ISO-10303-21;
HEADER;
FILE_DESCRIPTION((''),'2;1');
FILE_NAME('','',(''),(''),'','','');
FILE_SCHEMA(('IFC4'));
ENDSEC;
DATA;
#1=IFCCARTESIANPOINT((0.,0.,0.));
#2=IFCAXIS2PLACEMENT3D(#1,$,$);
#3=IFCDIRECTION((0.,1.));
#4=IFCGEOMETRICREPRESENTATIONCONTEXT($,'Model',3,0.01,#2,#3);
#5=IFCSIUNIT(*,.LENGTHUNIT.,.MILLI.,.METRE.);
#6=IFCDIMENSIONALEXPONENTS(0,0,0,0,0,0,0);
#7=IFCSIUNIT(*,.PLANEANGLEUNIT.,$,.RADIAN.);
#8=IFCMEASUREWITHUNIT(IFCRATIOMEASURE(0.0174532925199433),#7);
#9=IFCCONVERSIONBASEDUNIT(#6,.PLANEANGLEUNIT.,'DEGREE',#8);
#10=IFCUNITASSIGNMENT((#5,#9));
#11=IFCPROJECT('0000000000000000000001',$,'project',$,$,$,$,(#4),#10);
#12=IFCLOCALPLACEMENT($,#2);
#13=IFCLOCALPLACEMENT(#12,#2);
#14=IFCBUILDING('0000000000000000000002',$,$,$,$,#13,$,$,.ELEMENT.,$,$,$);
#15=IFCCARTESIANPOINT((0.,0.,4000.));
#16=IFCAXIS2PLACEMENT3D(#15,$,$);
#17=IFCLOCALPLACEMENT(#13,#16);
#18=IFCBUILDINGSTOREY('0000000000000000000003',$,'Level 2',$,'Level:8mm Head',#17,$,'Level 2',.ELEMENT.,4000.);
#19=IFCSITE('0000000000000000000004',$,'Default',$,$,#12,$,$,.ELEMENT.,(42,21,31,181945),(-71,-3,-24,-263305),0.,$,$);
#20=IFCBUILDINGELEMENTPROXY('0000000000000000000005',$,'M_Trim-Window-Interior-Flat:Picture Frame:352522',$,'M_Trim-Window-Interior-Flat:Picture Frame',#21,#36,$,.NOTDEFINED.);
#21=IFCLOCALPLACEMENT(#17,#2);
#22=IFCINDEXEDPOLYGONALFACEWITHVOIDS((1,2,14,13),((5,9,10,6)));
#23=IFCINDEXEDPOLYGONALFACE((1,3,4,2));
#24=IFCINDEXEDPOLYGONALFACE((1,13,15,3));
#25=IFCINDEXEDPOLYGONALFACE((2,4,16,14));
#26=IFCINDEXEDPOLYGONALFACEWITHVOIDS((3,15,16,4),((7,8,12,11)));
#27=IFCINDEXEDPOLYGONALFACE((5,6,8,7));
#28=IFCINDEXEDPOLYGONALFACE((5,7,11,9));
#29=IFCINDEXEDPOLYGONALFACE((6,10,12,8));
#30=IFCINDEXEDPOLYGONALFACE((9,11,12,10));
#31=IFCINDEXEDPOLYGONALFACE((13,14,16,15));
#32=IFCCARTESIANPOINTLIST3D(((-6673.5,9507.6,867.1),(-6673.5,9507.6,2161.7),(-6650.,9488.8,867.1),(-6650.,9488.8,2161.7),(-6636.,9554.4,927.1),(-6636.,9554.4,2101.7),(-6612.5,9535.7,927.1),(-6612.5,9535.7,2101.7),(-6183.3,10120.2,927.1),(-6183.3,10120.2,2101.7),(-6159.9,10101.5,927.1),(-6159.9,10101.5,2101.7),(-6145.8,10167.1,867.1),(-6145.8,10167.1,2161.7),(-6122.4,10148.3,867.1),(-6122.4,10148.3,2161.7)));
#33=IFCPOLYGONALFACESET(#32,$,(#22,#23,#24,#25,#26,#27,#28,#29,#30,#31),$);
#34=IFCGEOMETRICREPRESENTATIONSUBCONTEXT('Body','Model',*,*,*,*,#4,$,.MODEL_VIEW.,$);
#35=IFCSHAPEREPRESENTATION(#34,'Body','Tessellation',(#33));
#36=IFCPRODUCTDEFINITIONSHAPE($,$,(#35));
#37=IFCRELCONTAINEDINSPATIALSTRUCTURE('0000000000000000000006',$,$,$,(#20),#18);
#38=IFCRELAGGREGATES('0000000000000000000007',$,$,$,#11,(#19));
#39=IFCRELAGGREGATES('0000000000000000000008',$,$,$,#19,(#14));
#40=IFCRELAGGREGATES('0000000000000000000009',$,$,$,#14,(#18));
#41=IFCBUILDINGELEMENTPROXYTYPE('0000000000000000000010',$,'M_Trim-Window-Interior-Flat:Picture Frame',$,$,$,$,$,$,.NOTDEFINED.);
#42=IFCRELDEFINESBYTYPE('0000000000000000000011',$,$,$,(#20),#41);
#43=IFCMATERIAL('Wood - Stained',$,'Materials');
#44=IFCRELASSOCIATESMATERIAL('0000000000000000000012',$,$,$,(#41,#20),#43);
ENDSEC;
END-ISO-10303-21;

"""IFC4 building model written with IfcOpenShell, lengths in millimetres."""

from ifc_helpers import new_model, entity, si_unit, converted_unit, direction, frame, origin, place, context, subcontext, project, spatial, polyline, outline, extrude, source, transform, mapped, material, type_object, type_shapes, element, save


model = new_model("IFC4")

# Units and contexts
model_context = context("Model", 3, precision=0.01, world=origin(), true_north=direction((0.0, 1.0)))
body_context = subcontext(model_context, "Body", "Model", "MODEL_VIEW")
ifc_project = project(units=[si_unit("LENGTHUNIT", "METRE", prefix="MILLI"), converted_unit("PLANEANGLEUNIT", "DEGREE", entity("IfcRatioMeasure", 0.0174532925199433), si_unit("PLANEANGLEUNIT", "RADIAN"), dimensions=[0, 0, 0, 0, 0, 0, 0])], contexts=[model_context])

# Site, building, storey
site_placement = place(None, origin())
site = spatial("IfcSite", under=ifc_project, at=site_placement, Name="Default", CompositionType="ELEMENT", RefLatitude=(42, 21, 31, 181945), RefLongitude=(-71, -3, -24, -263305), RefElevation=0.0)
building_placement = place(site_placement, origin())
building = spatial("IfcBuilding", under=site, at=building_placement, CompositionType="ELEMENT")
storey_placement = place(building_placement, frame((0.0, 0.0, 4000.0)))
storey = spatial("IfcBuildingStorey", under=building, at=storey_placement, Name="Level 2", ObjectType="Level:8mm Head", LongName="Level 2", CompositionType="ELEMENT", Elevation=4000.0)

# Shared definitions
ifc_material_1 = material(Name="Wood - Stained", Category="Materials")

# Building element proxy
building_element_proxy_type_1 = type_object("IfcBuildingElementProxyType", Name="M_Trim-Window-Interior-Flat:Picture Frame", PredefinedType="NOTDEFINED", material=ifc_material_1)
shared_shape_1 = source(origin(), body_context, "Body", "SweptSolid", [
    extrude(outline(polyline([(-422.3, -647.3), (422.3, -647.3), (422.3, 647.3), (-422.3, 647.3), (-422.3, -647.3)]), holes=[polyline([(-362.3, -587.3), (-362.3, 587.3), (362.3, 587.3), (362.3, -587.3), (-362.3, -587.3)])]), frame((0.0, -600.0, 0.0), z_axis=(0.0, 0.0, 1.0), x_axis=(-1.0, 0.0, 0.0)), (0.0, 0.0, 1.0), 30.0),
])
type_shapes(building_element_proxy_type_1, [shared_shape_1])
for number, where, z_axis, x_axis, name in (
    (1, (-6386.2, 9818.6, 2114.4), (-0.780869, 0.624695, 0.0), (-0.624695, -0.780869, 0.0), "M_Trim-Window-Interior-Flat:Picture Frame:352522"),
):
    element("IfcBuildingElementProxy", number, at=place(storey_placement, frame(where, z_axis=z_axis, x_axis=x_axis)), inside=storey, type_object=building_element_proxy_type_1, material=ifc_material_1, Name=name, ObjectType="M_Trim-Window-Interior-Flat:Picture Frame", PredefinedType="NOTDEFINED", context=body_context, shape_type="MappedRepresentation", body=[
        mapped(shared_shape_1, transform((0.0, 0.0, 0.0), scale=1.0)),
    ])

save(model, "model.ifc")
